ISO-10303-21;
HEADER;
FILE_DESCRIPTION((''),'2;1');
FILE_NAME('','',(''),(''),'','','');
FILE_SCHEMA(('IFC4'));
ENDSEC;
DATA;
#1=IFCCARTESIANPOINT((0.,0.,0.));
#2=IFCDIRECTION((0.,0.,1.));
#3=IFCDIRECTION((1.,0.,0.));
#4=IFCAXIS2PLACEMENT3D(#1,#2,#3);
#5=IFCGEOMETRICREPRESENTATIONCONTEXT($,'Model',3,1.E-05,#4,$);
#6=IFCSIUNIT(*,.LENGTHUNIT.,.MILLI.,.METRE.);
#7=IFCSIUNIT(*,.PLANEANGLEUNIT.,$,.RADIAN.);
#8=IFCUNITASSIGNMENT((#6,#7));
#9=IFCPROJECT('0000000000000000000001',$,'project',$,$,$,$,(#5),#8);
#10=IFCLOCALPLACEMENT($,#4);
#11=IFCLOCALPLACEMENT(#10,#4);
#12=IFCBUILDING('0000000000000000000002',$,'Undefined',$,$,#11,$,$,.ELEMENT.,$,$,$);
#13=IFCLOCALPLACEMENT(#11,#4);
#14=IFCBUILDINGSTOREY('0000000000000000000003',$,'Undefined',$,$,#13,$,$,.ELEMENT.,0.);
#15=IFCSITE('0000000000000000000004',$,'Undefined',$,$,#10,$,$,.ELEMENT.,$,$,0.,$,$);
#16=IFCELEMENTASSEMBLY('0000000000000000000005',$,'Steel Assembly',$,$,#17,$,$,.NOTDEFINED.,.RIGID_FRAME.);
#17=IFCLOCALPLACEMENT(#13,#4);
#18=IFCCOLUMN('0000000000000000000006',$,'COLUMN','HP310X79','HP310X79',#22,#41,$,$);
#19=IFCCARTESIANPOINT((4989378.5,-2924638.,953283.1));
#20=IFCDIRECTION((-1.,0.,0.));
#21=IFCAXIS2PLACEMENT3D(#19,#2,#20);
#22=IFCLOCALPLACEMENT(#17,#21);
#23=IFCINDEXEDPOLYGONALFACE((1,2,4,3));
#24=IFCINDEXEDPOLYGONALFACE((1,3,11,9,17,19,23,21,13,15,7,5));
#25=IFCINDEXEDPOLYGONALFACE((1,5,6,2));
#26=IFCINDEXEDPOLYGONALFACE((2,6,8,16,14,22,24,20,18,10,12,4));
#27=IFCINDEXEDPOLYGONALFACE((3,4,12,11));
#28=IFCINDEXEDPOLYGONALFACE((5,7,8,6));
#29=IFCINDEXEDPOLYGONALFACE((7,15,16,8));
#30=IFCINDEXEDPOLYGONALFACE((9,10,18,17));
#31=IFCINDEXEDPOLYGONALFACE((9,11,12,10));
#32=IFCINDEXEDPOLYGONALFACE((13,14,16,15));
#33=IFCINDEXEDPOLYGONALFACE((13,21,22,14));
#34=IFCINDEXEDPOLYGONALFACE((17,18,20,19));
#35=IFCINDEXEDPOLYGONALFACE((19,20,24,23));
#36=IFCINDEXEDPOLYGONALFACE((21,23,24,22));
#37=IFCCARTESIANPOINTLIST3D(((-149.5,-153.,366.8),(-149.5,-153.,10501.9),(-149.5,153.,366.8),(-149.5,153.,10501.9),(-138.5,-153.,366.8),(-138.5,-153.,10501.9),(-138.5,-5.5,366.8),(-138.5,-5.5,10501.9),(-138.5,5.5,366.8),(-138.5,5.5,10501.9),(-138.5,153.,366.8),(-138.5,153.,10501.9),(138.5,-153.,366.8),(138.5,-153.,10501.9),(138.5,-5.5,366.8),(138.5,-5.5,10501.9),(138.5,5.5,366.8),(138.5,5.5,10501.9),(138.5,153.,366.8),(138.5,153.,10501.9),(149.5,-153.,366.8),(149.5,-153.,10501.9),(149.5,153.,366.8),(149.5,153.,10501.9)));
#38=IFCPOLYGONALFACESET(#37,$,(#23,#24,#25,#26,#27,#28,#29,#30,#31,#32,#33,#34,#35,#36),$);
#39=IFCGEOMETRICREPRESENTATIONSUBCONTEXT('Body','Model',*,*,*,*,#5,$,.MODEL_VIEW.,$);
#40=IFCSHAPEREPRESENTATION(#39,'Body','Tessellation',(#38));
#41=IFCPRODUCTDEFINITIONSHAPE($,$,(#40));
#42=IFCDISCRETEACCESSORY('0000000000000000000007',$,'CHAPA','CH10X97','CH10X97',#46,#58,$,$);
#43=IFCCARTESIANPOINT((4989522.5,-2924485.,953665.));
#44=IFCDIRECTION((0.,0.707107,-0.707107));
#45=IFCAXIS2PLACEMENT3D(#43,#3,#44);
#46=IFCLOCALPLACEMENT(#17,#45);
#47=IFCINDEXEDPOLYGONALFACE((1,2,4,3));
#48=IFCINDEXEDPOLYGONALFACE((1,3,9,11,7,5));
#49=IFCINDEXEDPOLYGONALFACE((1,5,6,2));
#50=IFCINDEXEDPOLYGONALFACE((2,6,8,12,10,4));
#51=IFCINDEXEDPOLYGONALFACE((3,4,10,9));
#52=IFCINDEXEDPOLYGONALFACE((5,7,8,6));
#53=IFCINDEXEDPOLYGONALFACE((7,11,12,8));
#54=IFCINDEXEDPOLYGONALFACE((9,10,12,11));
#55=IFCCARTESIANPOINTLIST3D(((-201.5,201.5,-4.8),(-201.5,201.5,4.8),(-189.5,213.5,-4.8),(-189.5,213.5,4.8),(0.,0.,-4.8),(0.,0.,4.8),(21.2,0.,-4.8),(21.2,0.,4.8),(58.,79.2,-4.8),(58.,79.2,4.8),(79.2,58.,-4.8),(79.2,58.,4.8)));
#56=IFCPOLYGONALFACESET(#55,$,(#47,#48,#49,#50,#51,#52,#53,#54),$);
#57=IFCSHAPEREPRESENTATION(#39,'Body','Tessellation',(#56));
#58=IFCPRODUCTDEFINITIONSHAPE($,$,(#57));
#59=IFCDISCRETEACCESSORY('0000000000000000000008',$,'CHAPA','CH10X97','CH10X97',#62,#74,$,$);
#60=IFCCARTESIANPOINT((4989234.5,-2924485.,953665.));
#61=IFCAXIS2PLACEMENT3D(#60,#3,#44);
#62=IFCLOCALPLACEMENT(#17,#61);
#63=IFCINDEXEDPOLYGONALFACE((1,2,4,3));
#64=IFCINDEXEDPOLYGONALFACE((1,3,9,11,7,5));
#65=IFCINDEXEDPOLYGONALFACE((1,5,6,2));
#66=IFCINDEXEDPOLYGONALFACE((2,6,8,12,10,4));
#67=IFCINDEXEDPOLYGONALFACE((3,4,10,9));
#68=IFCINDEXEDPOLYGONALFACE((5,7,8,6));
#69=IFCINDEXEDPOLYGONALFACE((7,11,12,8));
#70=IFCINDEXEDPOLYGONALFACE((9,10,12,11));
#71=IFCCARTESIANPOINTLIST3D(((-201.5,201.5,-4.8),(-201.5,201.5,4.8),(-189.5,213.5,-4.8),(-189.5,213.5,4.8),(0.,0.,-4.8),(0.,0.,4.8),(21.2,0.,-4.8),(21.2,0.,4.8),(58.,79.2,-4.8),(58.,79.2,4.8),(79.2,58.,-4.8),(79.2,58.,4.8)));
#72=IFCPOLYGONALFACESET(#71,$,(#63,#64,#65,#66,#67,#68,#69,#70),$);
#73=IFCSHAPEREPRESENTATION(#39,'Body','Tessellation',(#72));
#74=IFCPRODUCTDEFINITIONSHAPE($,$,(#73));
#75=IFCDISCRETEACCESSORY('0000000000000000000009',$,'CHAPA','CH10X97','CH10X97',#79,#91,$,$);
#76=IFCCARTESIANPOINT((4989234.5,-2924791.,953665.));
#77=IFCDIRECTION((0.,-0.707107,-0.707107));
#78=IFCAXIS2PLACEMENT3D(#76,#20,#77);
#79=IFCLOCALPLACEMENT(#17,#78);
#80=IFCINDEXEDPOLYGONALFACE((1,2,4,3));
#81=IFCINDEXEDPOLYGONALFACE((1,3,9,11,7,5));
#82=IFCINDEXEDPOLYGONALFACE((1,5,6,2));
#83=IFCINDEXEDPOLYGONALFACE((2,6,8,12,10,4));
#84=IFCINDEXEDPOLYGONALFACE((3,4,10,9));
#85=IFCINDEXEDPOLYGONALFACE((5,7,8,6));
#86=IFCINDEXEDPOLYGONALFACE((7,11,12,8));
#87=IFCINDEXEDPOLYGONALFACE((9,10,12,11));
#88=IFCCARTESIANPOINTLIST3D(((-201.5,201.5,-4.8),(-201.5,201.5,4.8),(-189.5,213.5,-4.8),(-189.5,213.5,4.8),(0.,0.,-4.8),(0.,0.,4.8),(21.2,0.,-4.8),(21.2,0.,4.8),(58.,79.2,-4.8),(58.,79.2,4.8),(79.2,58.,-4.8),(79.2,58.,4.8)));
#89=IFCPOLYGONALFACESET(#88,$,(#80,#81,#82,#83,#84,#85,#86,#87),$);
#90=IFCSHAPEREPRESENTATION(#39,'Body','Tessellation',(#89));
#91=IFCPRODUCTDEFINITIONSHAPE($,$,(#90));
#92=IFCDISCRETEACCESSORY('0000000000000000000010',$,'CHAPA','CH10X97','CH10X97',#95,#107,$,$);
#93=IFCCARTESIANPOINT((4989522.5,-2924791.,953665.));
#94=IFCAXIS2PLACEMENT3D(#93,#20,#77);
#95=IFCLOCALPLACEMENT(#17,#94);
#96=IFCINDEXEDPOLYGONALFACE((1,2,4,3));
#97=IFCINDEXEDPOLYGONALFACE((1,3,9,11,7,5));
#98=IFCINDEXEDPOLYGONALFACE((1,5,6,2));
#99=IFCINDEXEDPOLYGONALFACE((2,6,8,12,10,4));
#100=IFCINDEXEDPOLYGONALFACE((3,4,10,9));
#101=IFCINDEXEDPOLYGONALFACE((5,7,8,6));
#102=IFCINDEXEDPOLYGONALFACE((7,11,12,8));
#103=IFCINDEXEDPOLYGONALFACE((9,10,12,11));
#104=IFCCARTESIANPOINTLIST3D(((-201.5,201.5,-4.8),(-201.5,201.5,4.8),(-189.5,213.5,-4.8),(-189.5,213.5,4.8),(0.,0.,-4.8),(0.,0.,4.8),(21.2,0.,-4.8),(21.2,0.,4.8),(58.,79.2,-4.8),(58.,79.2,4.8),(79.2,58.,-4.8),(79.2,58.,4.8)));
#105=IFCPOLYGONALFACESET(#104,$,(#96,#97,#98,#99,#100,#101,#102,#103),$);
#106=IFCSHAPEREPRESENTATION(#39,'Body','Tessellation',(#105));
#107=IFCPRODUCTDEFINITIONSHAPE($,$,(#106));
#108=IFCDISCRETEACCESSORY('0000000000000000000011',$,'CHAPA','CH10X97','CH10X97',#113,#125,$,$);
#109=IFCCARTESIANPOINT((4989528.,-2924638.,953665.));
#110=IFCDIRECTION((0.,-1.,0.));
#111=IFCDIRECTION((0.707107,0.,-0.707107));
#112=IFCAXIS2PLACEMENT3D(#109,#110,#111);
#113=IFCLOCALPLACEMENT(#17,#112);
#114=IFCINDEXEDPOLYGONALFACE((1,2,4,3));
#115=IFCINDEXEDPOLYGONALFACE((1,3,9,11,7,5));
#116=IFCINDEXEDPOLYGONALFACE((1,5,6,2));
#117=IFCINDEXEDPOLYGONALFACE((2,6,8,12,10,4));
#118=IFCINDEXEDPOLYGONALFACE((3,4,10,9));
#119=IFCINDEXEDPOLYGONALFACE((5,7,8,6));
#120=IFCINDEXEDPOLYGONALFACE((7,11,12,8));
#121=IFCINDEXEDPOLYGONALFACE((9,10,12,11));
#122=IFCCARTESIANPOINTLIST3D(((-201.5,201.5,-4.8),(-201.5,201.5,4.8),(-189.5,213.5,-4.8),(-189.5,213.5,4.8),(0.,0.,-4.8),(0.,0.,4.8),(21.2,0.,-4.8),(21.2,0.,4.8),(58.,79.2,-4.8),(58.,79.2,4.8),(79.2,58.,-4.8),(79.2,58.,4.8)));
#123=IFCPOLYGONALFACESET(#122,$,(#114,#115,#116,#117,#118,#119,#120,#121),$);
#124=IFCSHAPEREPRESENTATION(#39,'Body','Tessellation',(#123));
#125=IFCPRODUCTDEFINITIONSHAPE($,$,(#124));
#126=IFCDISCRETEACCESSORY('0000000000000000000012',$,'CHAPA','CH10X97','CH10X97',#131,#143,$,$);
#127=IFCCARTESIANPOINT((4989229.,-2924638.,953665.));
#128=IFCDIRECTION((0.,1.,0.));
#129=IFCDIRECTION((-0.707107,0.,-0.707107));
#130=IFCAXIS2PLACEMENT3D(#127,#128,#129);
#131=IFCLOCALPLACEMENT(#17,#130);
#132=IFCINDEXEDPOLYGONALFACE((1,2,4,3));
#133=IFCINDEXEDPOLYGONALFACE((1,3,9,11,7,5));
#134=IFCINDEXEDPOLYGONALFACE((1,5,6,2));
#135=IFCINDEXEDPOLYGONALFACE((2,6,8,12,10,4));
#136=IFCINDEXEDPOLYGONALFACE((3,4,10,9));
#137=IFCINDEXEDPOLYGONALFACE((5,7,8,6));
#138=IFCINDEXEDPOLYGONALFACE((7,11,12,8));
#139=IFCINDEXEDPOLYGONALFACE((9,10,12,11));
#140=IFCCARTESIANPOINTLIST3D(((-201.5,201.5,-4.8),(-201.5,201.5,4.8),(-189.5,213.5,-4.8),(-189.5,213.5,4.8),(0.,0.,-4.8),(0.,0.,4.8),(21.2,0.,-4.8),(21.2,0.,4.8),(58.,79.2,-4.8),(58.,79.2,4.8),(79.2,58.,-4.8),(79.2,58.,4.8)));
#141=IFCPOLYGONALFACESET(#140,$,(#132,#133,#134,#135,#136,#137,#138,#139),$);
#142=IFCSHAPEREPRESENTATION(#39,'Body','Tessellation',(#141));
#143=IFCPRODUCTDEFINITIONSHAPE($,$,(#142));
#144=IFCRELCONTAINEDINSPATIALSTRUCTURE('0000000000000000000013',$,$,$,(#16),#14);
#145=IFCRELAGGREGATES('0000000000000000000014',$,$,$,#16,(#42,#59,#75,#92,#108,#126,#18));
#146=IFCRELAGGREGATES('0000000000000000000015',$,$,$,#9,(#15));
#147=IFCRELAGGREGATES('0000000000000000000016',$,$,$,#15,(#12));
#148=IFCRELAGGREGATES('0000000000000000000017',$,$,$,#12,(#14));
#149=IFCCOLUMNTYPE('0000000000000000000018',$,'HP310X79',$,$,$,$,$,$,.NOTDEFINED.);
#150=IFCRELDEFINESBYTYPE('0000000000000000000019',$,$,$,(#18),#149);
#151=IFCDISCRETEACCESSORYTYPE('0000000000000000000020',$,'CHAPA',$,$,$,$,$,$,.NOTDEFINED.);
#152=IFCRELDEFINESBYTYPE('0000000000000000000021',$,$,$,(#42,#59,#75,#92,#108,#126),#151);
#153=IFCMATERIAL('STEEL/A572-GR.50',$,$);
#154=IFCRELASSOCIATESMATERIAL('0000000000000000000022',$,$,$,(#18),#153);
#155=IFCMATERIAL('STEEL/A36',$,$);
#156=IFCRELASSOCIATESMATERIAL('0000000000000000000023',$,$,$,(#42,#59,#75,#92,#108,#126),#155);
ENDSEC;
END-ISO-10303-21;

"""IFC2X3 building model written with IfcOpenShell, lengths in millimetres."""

from ifc_helpers import new_model, si_unit, frame, origin_with_axes, origin_2d_with_axis, place, context, subcontext, project, spatial, polyline, i_section, outline, extrude, clip, halfspace, material, type_object, element, aggregate, save


model = new_model("IFC2X3")

# Units and contexts
model_context = context("Model", 3, precision=1e-05, world=origin_with_axes())
body_context = subcontext(model_context, "Body", "Model", "MODEL_VIEW")
ifc_project = project(units=[si_unit("LENGTHUNIT", "METRE", prefix="MILLI"), si_unit("PLANEANGLEUNIT", "RADIAN")], contexts=[model_context])

# Site, building, storey
site_placement = place(None, origin_with_axes())
site = spatial("IfcSite", under=ifc_project, at=site_placement, Name="Undefined", CompositionType="ELEMENT", RefElevation=0.0)
building_placement = place(site_placement, origin_with_axes())
building = spatial("IfcBuilding", under=site, at=building_placement, Name="Undefined", CompositionType="ELEMENT")
storey_placement = place(building_placement, origin_with_axes())
storey = spatial("IfcBuildingStorey", under=building, at=storey_placement, Name="Undefined", CompositionType="ELEMENT", Elevation=0.0)

# Element assembly, column
assembly_1_placement = place(storey_placement, origin_with_axes())
assembly_1 = element("IfcElementAssembly", 1, at=assembly_1_placement, inside=storey, Name="Steel Assembly", AssemblyPlace="NOTDEFINED", PredefinedType="RIGID_FRAME")
ifc_material_1 = material(Name="STEEL/A572-GR.50")
column_type = type_object("IfcColumnType", Name="HP310X79", PredefinedType="NOTDEFINED")
column_placement = place(assembly_1_placement, frame((4989378.5, -2924638.0, 953283.1), z_axis=(0.0, 0.0, 1.0), x_axis=(-1.0, 0.0, 0.0)))
column = element("IfcColumn", 2, at=column_placement, type_object=column_type, material=ifc_material_1, Name="COLUMN", Description="HP310X79", ObjectType="HP310X79", context=body_context, shape_type="Clipping", body=[
    clip(clip(clip(clip(clip(clip(extrude(i_section(OverallWidth=306.0, OverallDepth=299.0, WebThickness=11.0, FlangeThickness=11.0, at=origin_2d_with_axis()), frame((0.0, 0.0, 10868.8), z_axis=(0.0, 0.0, -1.0), x_axis=(0.0, 1.0, 0.0)), (0.0, 0.0, 1.0), 10502.0), halfspace(frame((-149.5, 153.0, 10501.9), z_axis=(0.0, 0.0, 1.0), x_axis=(1.0, 0.0, 0.0)), False)), halfspace(frame((-149.5, 153.0, 10501.9), z_axis=(0.0, 0.0, 1.0), x_axis=(1.0, 0.0, 0.0)), False)), halfspace(frame((-149.5, -153.0, 366.9), z_axis=(0.0, 0.0, -1.0), x_axis=(1.0, 0.0, 0.0)), False)), halfspace(frame((-149.5, 153.0, 10501.9), z_axis=(0.0, 0.0, 1.0), x_axis=(1.0, 0.0, 0.0)), False)), halfspace(frame((-149.5, 153.0, 10501.9), z_axis=(0.0, 0.0, 1.0), x_axis=(1.0, 0.0, 0.0)), False)), halfspace(frame((-149.5, 0.0, 366.9), z_axis=(0.0, 0.0, 1.0), x_axis=(0.0, 1.0, 0.0)), True)),
])

# Discrete accessories
ifc_material_2 = material(Name="STEEL/A36")
discrete_accessory_type_1 = type_object("IfcDiscreteAccessoryType", Name="CHAPA")
discrete_accessory_1_placement = place(assembly_1_placement, frame((4989522.5, -2924485.0, 953665.0), z_axis=(1.0, 0.0, 0.0), x_axis=(0.0, 0.707107, -0.707107)))
discrete_accessory_1 = element("IfcDiscreteAccessory", 3, at=discrete_accessory_1_placement, type_object=discrete_accessory_type_1, material=ifc_material_2, Name="CHAPA", Description="CH10X97", ObjectType="CH10X97", context=body_context, shape_type="SweptSolid", body=[
    extrude(outline(polyline([(0.0, 0.0), (21.2, 0.0), (79.2, 58.0), (58.0, 79.2), (-189.5, 213.5), (-201.5, 201.5), (0.0, 0.0)])), frame((0.0, 0.0, -4.8), z_axis=(0.0, 0.0, 1.0), x_axis=(1.0, 0.0, 0.0)), (0.0, 0.0, 1.0), 9.5),
])
discrete_accessory_2_placement = place(assembly_1_placement, frame((4989234.5, -2924485.0, 953665.0), z_axis=(1.0, 0.0, 0.0), x_axis=(0.0, 0.707107, -0.707107)))
discrete_accessory_2 = element("IfcDiscreteAccessory", 4, at=discrete_accessory_2_placement, type_object=discrete_accessory_type_1, material=ifc_material_2, Name="CHAPA", Description="CH10X97", ObjectType="CH10X97", context=body_context, shape_type="SweptSolid", body=[
    extrude(outline(polyline([(0.0, 0.0), (21.2, 0.0), (79.2, 58.0), (58.0, 79.2), (-189.5, 213.5), (-201.5, 201.5), (0.0, 0.0)])), frame((0.0, 0.0, -4.8), z_axis=(0.0, 0.0, 1.0), x_axis=(1.0, 0.0, 0.0)), (0.0, 0.0, 1.0), 9.5),
])
discrete_accessory_3_placement = place(assembly_1_placement, frame((4989234.5, -2924791.0, 953665.0), z_axis=(-1.0, 0.0, 0.0), x_axis=(0.0, -0.707107, -0.707107)))
discrete_accessory_3 = element("IfcDiscreteAccessory", 5, at=discrete_accessory_3_placement, type_object=discrete_accessory_type_1, material=ifc_material_2, Name="CHAPA", Description="CH10X97", ObjectType="CH10X97", context=body_context, shape_type="SweptSolid", body=[
    extrude(outline(polyline([(0.0, 0.0), (21.2, 0.0), (79.2, 58.0), (58.0, 79.2), (-189.5, 213.5), (-201.5, 201.5), (0.0, 0.0)])), frame((0.0, 0.0, -4.8), z_axis=(0.0, 0.0, 1.0), x_axis=(1.0, 0.0, 0.0)), (0.0, 0.0, 1.0), 9.5),
])
discrete_accessory_4_placement = place(assembly_1_placement, frame((4989522.5, -2924791.0, 953665.0), z_axis=(-1.0, 0.0, 0.0), x_axis=(0.0, -0.707107, -0.707107)))
discrete_accessory_4 = element("IfcDiscreteAccessory", 6, at=discrete_accessory_4_placement, type_object=discrete_accessory_type_1, material=ifc_material_2, Name="CHAPA", Description="CH10X97", ObjectType="CH10X97", context=body_context, shape_type="SweptSolid", body=[
    extrude(outline(polyline([(0.0, 0.0), (21.2, 0.0), (79.2, 58.0), (58.0, 79.2), (-189.5, 213.5), (-201.5, 201.5), (0.0, 0.0)])), frame((0.0, 0.0, -4.8), z_axis=(0.0, 0.0, 1.0), x_axis=(1.0, 0.0, 0.0)), (0.0, 0.0, 1.0), 9.5),
])
discrete_accessory_5_placement = place(assembly_1_placement, frame((4989528.0, -2924638.0, 953665.0), z_axis=(0.0, -1.0, 0.0), x_axis=(0.707107, 0.0, -0.707107)))
discrete_accessory_5 = element("IfcDiscreteAccessory", 7, at=discrete_accessory_5_placement, type_object=discrete_accessory_type_1, material=ifc_material_2, Name="CHAPA", Description="CH10X97", ObjectType="CH10X97", context=body_context, shape_type="SweptSolid", body=[
    extrude(outline(polyline([(0.0, 0.0), (21.2, 0.0), (79.2, 58.0), (58.0, 79.2), (-189.5, 213.5), (-201.5, 201.5), (0.0, 0.0)])), frame((0.0, 0.0, -4.8), z_axis=(0.0, 0.0, 1.0), x_axis=(1.0, 0.0, 0.0)), (0.0, 0.0, 1.0), 9.5),
])
discrete_accessory_6_placement = place(assembly_1_placement, frame((4989229.0, -2924638.0, 953665.0), z_axis=(0.0, 1.0, 0.0), x_axis=(-0.707107, 0.0, -0.707107)))
discrete_accessory_6 = element("IfcDiscreteAccessory", 8, at=discrete_accessory_6_placement, type_object=discrete_accessory_type_1, material=ifc_material_2, Name="CHAPA", Description="CH10X97", ObjectType="CH10X97", context=body_context, shape_type="SweptSolid", body=[
    extrude(outline(polyline([(0.0, 0.0), (21.2, 0.0), (79.2, 58.0), (58.0, 79.2), (-189.5, 213.5), (-201.5, 201.5), (0.0, 0.0)])), frame((0.0, 0.0, -4.8), z_axis=(0.0, 0.0, 1.0), x_axis=(1.0, 0.0, 0.0)), (0.0, 0.0, 1.0), 9.5),
])

aggregate(assembly_1, [discrete_accessory_1, discrete_accessory_2, discrete_accessory_3, discrete_accessory_4, discrete_accessory_5, discrete_accessory_6, column])

save(model, "model.ifc")
